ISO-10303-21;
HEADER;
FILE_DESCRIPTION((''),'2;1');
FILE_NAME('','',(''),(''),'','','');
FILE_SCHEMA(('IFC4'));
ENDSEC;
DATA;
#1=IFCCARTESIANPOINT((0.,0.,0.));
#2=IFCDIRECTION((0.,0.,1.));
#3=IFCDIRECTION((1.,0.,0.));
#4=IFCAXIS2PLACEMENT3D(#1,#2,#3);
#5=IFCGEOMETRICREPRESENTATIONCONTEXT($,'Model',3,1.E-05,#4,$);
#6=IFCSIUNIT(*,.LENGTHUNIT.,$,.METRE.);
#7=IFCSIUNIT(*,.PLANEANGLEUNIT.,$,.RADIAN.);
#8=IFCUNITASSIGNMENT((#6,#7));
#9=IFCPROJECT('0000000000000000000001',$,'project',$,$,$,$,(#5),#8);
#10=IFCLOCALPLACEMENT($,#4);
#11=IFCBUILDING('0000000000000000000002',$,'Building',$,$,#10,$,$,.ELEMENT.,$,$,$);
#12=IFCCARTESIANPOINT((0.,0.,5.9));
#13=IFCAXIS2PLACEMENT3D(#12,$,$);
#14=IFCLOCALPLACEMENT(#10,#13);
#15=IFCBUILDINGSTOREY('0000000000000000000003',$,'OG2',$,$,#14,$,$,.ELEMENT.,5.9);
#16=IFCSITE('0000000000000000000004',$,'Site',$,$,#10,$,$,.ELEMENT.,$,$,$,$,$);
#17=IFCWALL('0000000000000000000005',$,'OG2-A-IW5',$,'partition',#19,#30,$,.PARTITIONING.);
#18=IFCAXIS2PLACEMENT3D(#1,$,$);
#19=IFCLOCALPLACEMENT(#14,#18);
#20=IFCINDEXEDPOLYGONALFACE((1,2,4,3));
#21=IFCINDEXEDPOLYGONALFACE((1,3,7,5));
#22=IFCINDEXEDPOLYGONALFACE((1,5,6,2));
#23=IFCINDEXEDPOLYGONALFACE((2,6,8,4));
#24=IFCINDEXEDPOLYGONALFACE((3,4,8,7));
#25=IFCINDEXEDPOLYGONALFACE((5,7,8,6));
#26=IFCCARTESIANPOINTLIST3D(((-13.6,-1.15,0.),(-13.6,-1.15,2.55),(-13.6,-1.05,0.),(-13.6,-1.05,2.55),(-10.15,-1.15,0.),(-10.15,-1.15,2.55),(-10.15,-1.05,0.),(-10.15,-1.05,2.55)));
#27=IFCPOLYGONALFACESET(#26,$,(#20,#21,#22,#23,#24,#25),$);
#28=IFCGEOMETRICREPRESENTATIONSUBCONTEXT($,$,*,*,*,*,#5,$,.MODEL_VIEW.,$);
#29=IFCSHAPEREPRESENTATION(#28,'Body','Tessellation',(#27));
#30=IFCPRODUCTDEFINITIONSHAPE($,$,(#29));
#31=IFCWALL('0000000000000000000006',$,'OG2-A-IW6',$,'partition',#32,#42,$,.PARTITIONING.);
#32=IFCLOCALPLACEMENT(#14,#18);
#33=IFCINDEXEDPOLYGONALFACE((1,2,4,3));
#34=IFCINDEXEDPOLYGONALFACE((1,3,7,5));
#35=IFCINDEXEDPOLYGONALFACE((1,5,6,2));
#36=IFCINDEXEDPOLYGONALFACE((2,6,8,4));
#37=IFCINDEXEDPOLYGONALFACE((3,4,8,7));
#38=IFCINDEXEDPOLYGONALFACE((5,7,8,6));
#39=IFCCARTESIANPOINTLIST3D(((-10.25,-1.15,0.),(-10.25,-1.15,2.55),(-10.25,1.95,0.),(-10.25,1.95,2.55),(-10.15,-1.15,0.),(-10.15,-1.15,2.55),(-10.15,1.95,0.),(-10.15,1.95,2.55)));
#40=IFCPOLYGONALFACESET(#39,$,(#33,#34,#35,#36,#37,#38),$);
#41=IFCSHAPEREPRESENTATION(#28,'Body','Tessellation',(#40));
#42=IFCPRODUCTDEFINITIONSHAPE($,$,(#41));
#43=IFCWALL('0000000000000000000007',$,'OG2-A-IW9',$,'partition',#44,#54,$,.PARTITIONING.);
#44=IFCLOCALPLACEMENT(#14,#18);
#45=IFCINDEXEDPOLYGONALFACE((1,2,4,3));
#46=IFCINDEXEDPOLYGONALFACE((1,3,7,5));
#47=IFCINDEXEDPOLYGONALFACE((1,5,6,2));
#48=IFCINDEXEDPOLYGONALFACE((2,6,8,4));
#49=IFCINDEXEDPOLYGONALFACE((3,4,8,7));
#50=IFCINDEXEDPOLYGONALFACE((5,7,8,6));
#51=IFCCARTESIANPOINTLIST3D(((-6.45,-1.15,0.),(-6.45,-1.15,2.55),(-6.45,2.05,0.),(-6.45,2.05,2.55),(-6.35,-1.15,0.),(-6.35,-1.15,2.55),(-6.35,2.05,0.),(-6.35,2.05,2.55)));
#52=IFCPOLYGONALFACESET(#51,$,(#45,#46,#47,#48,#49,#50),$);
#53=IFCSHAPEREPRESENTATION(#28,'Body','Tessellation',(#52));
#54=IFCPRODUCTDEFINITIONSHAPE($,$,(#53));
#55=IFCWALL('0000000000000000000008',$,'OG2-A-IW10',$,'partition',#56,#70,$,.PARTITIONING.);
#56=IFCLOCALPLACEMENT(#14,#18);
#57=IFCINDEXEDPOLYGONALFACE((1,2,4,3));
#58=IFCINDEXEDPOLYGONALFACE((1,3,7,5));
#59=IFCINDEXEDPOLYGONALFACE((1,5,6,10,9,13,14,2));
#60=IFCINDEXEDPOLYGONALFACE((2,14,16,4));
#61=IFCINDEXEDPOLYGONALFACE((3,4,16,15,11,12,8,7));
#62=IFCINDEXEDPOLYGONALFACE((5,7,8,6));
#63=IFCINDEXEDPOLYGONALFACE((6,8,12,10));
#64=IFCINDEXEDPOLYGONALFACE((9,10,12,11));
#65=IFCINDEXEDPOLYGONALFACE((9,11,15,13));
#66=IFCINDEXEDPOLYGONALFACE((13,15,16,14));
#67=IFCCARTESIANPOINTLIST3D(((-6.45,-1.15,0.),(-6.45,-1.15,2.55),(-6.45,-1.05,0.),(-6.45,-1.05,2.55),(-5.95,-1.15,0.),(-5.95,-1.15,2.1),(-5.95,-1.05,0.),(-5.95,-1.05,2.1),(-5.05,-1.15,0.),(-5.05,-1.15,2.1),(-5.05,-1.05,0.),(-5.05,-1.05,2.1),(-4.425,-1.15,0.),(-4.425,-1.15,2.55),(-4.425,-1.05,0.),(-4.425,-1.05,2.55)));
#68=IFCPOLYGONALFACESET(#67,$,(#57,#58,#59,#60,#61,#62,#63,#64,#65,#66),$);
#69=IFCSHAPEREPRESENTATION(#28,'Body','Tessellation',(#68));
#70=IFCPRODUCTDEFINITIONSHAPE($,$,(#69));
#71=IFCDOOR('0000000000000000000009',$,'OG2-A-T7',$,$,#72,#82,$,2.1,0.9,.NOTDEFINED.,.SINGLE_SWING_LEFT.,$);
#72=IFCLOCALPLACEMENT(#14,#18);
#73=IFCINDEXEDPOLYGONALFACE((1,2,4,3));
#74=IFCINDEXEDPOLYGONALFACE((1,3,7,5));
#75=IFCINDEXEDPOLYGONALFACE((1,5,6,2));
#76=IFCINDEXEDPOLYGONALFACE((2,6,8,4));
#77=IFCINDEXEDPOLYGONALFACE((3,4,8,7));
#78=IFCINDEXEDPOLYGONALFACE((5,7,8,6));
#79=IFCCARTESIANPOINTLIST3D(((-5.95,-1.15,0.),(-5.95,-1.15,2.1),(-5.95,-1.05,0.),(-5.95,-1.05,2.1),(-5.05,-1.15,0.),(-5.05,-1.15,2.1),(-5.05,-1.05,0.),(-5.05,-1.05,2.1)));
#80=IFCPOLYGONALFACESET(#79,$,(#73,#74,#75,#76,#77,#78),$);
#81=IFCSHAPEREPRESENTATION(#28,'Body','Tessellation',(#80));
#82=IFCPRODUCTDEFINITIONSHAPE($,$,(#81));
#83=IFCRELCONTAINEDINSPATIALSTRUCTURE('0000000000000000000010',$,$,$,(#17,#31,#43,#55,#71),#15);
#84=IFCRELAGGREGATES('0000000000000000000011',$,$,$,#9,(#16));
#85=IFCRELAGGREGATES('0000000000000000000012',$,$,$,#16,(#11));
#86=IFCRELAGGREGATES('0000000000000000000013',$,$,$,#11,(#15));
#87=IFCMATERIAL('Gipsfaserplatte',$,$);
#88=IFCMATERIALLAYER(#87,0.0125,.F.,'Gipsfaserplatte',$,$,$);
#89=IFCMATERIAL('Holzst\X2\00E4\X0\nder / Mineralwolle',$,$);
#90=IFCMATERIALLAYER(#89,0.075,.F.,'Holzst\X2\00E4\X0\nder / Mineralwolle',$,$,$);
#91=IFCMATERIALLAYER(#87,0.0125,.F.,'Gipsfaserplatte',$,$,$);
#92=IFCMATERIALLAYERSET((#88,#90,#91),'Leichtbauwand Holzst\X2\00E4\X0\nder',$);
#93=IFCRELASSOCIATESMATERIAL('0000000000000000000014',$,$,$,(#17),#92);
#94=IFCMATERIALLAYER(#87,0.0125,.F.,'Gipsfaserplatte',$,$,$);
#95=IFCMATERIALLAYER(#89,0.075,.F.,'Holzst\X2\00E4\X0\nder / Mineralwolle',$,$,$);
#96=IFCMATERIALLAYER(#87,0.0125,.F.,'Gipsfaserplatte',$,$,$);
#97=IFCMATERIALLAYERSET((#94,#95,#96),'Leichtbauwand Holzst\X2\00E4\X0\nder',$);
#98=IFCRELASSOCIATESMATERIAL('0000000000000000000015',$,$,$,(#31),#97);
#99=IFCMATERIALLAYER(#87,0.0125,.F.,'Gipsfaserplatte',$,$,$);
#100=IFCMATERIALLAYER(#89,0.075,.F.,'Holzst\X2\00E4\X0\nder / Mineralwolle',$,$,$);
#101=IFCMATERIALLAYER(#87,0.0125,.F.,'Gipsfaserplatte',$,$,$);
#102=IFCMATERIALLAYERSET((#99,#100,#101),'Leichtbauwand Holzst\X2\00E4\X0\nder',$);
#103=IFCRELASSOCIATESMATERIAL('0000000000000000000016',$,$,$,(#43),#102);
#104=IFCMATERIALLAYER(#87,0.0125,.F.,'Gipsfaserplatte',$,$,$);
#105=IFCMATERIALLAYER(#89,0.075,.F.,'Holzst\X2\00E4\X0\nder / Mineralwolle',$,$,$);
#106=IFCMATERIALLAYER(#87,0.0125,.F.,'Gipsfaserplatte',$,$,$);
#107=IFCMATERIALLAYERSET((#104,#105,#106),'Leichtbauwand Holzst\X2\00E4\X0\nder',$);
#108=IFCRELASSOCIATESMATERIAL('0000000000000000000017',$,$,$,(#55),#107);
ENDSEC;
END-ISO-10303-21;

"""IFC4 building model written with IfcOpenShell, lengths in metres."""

from ifc_helpers import new_model, si_unit, frame, frame_2d, origin, origin_with_axes, place, context, subcontext, project, spatial, rectangle, extrude, material, layer, layer_set, element, fill, save


model = new_model("IFC4")

# Units and contexts
model_context = context("Model", 3, precision=1e-05, world=origin_with_axes())
sub_context = subcontext(model_context, None, None, "MODEL_VIEW")
ifc_project = project(units=[si_unit("LENGTHUNIT", "METRE"), si_unit("PLANEANGLEUNIT", "RADIAN")], contexts=[model_context])

# Site, building, storey
placement = place(None, origin_with_axes())
site = spatial("IfcSite", under=ifc_project, at=placement, Name="Site", CompositionType="ELEMENT")
building = spatial("IfcBuilding", under=site, at=placement, Name="Building", CompositionType="ELEMENT")
storey_placement = place(placement, frame((0.0, 0.0, 5.9)))
storey = spatial("IfcBuildingStorey", under=building, at=storey_placement, Name="OG2", CompositionType="ELEMENT", Elevation=5.9)

# Shared definitions
ifc_material_1 = material(Name="Gipsfaserplatte")

# Walls
ifc_layer_1 = layer(ifc_material_1, 0.0125, ventilated=False, Name="Gipsfaserplatte")
ifc_material_2 = material(Name="Holzständer / Mineralwolle")
ifc_layer_2 = layer(ifc_material_2, 0.075, ventilated=False, Name="Holzständer / Mineralwolle")
ifc_layer_3 = layer(ifc_material_1, 0.0125, ventilated=False, Name="Gipsfaserplatte")
ifc_layer_set_1 = layer_set([ifc_layer_1, ifc_layer_2, ifc_layer_3], Name="Leichtbauwand Holzständer")
wall_1_placement = place(storey_placement, frame((-13.6, -1.1, 0.0), z_axis=(0.0, 0.0, 1.0), x_axis=(1.0, 0.0, 0.0)))
element("IfcWall", 1, at=wall_1_placement, inside=storey, material=ifc_layer_set_1, Name="OG2-A-IW5", ObjectType="partition", PredefinedType="PARTITIONING", context=sub_context, shape_type="SweptSolid", body=[
    extrude(rectangle(XDim=3.45, YDim=0.1, at=frame_2d((1.725, 0.0))), origin(), (0.0, 0.0, 1.0), 2.55),
])
ifc_layer_4 = layer(ifc_material_1, 0.0125, ventilated=False, Name="Gipsfaserplatte")
ifc_layer_5 = layer(ifc_material_2, 0.075, ventilated=False, Name="Holzständer / Mineralwolle")
ifc_layer_6 = layer(ifc_material_1, 0.0125, ventilated=False, Name="Gipsfaserplatte")
ifc_layer_set_2 = layer_set([ifc_layer_4, ifc_layer_5, ifc_layer_6], Name="Leichtbauwand Holzständer")
wall_2_placement = place(storey_placement, frame((-10.2, -1.15, 0.0), z_axis=(0.0, 0.0, 1.0), x_axis=(0.0, 1.0, 0.0)))
element("IfcWall", 2, at=wall_2_placement, inside=storey, material=ifc_layer_set_2, Name="OG2-A-IW6", ObjectType="partition", PredefinedType="PARTITIONING", context=sub_context, shape_type="SweptSolid", body=[
    extrude(rectangle(XDim=3.1, YDim=0.1, at=frame_2d((1.55, 0.0))), origin(), (0.0, 0.0, 1.0), 2.55),
])
ifc_layer_7 = layer(ifc_material_1, 0.0125, ventilated=False, Name="Gipsfaserplatte")
ifc_layer_8 = layer(ifc_material_2, 0.075, ventilated=False, Name="Holzständer / Mineralwolle")
ifc_layer_9 = layer(ifc_material_1, 0.0125, ventilated=False, Name="Gipsfaserplatte")
ifc_layer_set_3 = layer_set([ifc_layer_7, ifc_layer_8, ifc_layer_9], Name="Leichtbauwand Holzständer")
wall_3_placement = place(storey_placement, frame((-6.4, -1.15, 0.0), z_axis=(0.0, 0.0, 1.0), x_axis=(0.0, 1.0, 0.0)))
element("IfcWall", 3, at=wall_3_placement, inside=storey, material=ifc_layer_set_3, Name="OG2-A-IW9", ObjectType="partition", PredefinedType="PARTITIONING", context=sub_context, shape_type="SweptSolid", body=[
    extrude(rectangle(XDim=3.2, YDim=0.1, at=frame_2d((1.6, 0.0))), origin(), (0.0, 0.0, 1.0), 2.55),
])

# Wall, opening, door
ifc_layer_10 = layer(ifc_material_1, 0.0125, ventilated=False, Name="Gipsfaserplatte")
ifc_layer_11 = layer(ifc_material_2, 0.075, ventilated=False, Name="Holzständer / Mineralwolle")
ifc_layer_12 = layer(ifc_material_1, 0.0125, ventilated=False, Name="Gipsfaserplatte")
ifc_layer_set_4 = layer_set([ifc_layer_10, ifc_layer_11, ifc_layer_12], Name="Leichtbauwand Holzständer")
wall_4_placement = place(storey_placement, frame((-6.45, -1.1, 0.0), z_axis=(0.0, 0.0, 1.0), x_axis=(1.0, 0.0, 0.0)))
wall_4 = element("IfcWall", 4, at=wall_4_placement, inside=storey, material=ifc_layer_set_4, Name="OG2-A-IW10", ObjectType="partition", PredefinedType="PARTITIONING", context=sub_context, shape_type="SweptSolid", body=[
    extrude(rectangle(XDim=2.025, YDim=0.1, at=frame_2d((1.0125, 0.0))), origin(), (0.0, 0.0, 1.0), 2.55),
])
opening_1_placement = place(wall_4_placement, frame((0.95, 0.1, 0.0), z_axis=(0.0, -1.0, 0.0), x_axis=(1.0, 0.0, 0.0)))
opening_1 = element("IfcOpeningElement", 5, at=opening_1_placement, cuts=wall_4, PredefinedType="OPENING", context=sub_context, shape_type="SweptSolid", body=[
    extrude(rectangle(XDim=0.9, YDim=2.1, at=frame_2d((0.0, 1.05))), origin(), (0.0, 0.0, 1.0), 0.2),
])
door_1_placement = place(wall_4_placement, frame((0.95, 0.05, 0.0), z_axis=(0.0, -1.0, 0.0), x_axis=(1.0, 0.0, 0.0)))
door_1 = element("IfcDoor", 6, at=door_1_placement, inside=storey, Name="OG2-A-T7", OperationType="SINGLE_SWING_LEFT", OverallHeight=2.1, OverallWidth=0.9, PredefinedType="NOTDEFINED", context=sub_context, shape_type="SweptSolid", body=[
    extrude(rectangle(XDim=0.9, YDim=2.1, at=frame_2d((0.0, 1.05))), origin(), (0.0, 0.0, 1.0), 0.1),
])
fill(opening_1, door_1)

save(model, "model.ifc")
